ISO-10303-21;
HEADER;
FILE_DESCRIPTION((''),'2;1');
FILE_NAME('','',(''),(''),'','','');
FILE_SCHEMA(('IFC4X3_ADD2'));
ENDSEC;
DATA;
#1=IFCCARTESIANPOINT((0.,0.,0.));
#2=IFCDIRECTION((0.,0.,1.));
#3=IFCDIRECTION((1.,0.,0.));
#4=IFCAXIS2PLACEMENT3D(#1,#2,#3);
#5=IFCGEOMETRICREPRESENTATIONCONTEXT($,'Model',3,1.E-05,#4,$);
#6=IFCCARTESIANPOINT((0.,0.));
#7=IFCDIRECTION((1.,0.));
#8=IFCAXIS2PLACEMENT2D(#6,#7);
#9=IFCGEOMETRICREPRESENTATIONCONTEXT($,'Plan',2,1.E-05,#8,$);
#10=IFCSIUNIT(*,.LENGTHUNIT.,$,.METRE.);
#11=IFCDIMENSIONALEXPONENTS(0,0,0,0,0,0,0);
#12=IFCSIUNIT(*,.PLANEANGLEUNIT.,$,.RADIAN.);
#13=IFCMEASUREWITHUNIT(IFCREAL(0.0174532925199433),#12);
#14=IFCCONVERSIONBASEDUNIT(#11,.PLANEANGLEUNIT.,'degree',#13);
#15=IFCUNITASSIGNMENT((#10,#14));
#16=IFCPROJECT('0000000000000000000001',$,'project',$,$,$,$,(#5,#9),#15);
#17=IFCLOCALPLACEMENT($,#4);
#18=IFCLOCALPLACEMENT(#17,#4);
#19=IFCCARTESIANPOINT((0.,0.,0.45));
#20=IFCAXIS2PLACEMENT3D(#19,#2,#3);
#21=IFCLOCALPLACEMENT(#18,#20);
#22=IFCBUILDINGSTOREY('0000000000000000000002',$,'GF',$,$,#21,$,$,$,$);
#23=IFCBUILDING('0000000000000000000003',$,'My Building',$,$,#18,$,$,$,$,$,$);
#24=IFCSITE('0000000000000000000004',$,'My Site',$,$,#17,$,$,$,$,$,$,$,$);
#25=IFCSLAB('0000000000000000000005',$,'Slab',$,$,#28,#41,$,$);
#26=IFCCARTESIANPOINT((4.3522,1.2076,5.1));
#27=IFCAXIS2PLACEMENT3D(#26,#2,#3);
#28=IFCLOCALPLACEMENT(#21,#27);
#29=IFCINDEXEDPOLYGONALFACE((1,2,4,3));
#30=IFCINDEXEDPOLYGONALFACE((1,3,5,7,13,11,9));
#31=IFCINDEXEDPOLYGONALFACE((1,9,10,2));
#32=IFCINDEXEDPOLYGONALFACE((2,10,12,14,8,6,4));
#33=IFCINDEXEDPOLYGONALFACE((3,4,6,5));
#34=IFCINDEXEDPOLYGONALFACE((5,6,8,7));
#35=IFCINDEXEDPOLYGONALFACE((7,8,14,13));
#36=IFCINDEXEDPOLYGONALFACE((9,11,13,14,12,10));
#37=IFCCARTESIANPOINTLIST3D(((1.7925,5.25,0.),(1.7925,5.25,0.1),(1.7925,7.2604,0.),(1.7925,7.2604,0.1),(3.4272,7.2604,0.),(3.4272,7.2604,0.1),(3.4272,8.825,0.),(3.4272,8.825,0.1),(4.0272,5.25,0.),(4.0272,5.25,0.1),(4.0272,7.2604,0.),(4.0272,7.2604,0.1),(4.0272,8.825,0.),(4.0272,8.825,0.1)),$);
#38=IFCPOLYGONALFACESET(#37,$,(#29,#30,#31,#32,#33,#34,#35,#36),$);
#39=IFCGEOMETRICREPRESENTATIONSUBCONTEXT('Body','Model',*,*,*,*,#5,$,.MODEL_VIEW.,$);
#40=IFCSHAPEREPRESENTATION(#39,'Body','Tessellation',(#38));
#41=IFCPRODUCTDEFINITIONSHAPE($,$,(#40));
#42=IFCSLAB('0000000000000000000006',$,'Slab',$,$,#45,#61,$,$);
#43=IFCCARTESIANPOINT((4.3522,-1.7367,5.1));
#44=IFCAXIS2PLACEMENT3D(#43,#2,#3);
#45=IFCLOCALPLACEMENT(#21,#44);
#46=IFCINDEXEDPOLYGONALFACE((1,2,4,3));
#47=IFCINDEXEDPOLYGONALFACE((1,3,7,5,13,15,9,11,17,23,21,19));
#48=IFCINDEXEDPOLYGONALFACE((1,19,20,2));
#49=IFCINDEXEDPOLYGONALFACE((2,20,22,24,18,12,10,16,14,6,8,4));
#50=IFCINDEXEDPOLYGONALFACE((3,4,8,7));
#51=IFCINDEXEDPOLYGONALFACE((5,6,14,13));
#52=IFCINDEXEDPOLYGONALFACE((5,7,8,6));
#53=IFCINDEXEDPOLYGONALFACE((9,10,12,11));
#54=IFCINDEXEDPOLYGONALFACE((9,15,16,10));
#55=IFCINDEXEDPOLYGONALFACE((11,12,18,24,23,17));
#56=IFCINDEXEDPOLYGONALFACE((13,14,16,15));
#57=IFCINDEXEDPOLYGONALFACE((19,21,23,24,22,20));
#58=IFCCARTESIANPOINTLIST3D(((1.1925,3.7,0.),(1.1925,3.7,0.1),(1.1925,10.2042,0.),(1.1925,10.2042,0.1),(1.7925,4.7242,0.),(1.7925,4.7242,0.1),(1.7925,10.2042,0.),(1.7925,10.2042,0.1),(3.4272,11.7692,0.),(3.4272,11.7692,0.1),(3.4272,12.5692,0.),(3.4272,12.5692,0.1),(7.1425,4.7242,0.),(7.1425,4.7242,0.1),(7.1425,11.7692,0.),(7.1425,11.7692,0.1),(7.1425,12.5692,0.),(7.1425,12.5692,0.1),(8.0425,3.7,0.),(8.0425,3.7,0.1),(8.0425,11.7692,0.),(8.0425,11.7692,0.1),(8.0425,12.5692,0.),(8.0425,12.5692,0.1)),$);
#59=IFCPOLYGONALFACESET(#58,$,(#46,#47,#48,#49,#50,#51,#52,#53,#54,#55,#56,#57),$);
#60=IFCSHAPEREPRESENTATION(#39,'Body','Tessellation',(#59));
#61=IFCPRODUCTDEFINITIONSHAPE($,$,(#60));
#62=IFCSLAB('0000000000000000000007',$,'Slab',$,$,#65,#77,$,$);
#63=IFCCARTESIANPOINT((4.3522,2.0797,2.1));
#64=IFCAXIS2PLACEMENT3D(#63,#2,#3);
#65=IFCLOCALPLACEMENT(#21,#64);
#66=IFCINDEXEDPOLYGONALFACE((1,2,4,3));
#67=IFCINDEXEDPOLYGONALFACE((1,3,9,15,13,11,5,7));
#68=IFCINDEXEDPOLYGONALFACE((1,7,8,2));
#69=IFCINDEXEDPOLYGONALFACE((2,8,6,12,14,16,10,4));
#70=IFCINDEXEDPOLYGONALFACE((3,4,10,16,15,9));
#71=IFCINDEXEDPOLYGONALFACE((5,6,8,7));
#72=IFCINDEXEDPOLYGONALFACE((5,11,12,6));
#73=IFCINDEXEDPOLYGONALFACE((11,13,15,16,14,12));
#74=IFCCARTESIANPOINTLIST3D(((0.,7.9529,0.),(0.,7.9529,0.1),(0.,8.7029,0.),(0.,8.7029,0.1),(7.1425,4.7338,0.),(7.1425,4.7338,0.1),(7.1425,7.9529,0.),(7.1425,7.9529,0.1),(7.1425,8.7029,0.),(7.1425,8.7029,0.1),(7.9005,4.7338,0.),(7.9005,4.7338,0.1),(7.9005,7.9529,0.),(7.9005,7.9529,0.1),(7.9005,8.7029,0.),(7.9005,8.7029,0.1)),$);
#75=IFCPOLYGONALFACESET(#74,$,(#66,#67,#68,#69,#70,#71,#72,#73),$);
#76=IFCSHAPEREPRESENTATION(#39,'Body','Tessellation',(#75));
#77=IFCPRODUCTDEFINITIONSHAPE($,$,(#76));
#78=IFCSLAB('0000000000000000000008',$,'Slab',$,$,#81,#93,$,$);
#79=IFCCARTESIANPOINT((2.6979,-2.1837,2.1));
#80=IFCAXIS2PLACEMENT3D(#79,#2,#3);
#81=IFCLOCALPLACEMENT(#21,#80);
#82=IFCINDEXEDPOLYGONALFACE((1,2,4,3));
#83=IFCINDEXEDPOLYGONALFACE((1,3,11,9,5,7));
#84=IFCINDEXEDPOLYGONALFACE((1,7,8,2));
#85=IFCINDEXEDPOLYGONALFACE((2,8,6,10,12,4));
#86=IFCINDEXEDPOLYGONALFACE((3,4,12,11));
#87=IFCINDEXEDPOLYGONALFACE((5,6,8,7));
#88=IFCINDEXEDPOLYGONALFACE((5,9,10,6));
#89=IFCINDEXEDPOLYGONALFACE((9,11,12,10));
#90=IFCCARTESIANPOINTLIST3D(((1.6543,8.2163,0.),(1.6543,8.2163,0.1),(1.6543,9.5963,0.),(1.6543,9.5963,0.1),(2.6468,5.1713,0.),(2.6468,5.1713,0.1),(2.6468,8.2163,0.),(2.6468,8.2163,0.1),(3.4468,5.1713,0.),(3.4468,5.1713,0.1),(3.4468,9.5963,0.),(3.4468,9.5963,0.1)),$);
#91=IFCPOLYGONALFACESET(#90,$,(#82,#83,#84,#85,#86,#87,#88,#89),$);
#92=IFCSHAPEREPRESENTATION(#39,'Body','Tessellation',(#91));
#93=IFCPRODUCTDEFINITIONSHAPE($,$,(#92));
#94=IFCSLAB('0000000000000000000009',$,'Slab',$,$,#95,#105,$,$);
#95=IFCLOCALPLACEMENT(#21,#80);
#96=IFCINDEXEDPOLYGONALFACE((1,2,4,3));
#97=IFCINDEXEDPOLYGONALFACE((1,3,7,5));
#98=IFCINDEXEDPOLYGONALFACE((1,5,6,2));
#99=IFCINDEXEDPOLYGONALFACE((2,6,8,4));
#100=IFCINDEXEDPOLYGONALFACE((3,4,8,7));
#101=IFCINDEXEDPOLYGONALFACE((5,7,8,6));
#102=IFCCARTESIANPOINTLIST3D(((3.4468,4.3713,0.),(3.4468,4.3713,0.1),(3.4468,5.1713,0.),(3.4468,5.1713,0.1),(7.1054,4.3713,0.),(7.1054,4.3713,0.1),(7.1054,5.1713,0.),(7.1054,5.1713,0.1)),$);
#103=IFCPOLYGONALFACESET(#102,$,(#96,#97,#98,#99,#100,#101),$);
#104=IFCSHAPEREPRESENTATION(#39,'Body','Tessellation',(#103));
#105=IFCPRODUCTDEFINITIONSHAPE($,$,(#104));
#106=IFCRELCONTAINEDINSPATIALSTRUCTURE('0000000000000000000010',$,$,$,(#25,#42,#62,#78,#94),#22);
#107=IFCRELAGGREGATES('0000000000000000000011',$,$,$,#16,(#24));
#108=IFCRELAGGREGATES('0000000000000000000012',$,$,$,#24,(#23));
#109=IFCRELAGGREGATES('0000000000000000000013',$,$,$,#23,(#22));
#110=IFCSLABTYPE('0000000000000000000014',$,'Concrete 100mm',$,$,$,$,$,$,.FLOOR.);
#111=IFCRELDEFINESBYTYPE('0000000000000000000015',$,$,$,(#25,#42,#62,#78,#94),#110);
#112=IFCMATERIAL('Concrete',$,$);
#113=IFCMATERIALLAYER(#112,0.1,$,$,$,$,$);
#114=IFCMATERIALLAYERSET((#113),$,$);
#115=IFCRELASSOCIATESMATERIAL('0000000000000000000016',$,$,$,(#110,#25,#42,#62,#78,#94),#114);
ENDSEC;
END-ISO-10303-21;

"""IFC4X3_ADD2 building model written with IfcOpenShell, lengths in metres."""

from ifc_helpers import new_model, entity, si_unit, converted_unit, frame, origin_with_axes, origin_2d_with_axis, place, context, subcontext, project, spatial, indexed_curve, outline, extrude, material, layer, layer_set, layer_usage, type_object, element, save


model = new_model("IFC4X3_ADD2")

# Units and contexts
model_context = context("Model", 3, precision=1e-05, world=origin_with_axes())
plan_context = context("Plan", 2, precision=1e-05, world=origin_2d_with_axis())
body_context_1 = subcontext(model_context, "Body", "Model", "MODEL_VIEW")
ifc_project = project(units=[si_unit("LENGTHUNIT", "METRE"), converted_unit("PLANEANGLEUNIT", "degree", entity("IfcReal", 0.0174532925199433), si_unit("PLANEANGLEUNIT", "RADIAN"), dimensions=[0, 0, 0, 0, 0, 0, 0])], contexts=[model_context, plan_context])

# Site, building, storey
site_placement = place(None, origin_with_axes())
site = spatial("IfcSite", under=ifc_project, at=site_placement, Name="My Site")
building_placement = place(site_placement, origin_with_axes())
building = spatial("IfcBuilding", under=site, at=building_placement, Name="My Building")
storey_placement = place(building_placement, frame((0.0, 0.0, 0.45), z_axis=(0.0, 0.0, 1.0), x_axis=(1.0, 0.0, 0.0)))
storey = spatial("IfcBuildingStorey", under=building, at=storey_placement, Name="GF")

# Slabs
ifc_material_1 = material(Name="Concrete")
ifc_layer_1 = layer(ifc_material_1, 0.1)
ifc_layer_set_1 = layer_set([ifc_layer_1])
ifc_layer_usage_1 = layer_usage(ifc_layer_set_1, "AXIS3", "POSITIVE", 0.0)
slab_type = type_object("IfcSlabType", Name="Concrete 100mm", PredefinedType="FLOOR", material=ifc_layer_set_1)
slab_1_placement = place(storey_placement, frame((4.3522, 1.2076, 5.1), z_axis=(0.0, 0.0, 1.0), x_axis=(1.0, 0.0, 0.0)))
element("IfcSlab", 1, at=slab_1_placement, inside=storey, type_object=slab_type, material=ifc_layer_usage_1, Name="Slab", context=body_context_1, shape_type="SweptSolid", body=[
    extrude(outline(indexed_curve([(1.7925, 7.2604), (1.7925, 5.25), (4.0272, 5.25), (4.0272, 7.2604), (4.0272, 8.825), (3.4272, 8.825), (3.4272, 7.2604), (1.7925, 7.2604)])), origin_with_axes(), (0.0, 0.0, 1.0), 0.1),
])
ifc_layer_usage_2 = layer_usage(ifc_layer_set_1, "AXIS3", "POSITIVE", 0.0)
slab_2_placement = place(storey_placement, frame((4.3522, -1.7367, 5.1), z_axis=(0.0, 0.0, 1.0), x_axis=(1.0, 0.0, 0.0)))
element("IfcSlab", 2, at=slab_2_placement, inside=storey, type_object=slab_type, material=ifc_layer_usage_2, Name="Slab", context=body_context_1, shape_type="SweptSolid", body=[
    extrude(outline(indexed_curve([(8.0425, 11.7692), (8.0425, 12.5692), (7.1425, 12.5692), (3.4272, 12.5692), (3.4272, 11.7692), (7.1425, 11.7692), (7.1425, 4.7242), (1.7925, 4.7242), (1.7925, 10.2042), (1.1925, 10.2042), (1.1925, 3.7), (8.0425, 3.7), (8.0425, 11.7692)])), origin_with_axes(), (0.0, 0.0, 1.0), 0.1),
])
ifc_layer_usage_3 = layer_usage(ifc_layer_set_1, "AXIS3", "POSITIVE", 0.0)
slab_3_placement = place(storey_placement, frame((4.3522, 2.0797, 2.1), z_axis=(0.0, 0.0, 1.0), x_axis=(1.0, 0.0, 0.0)))
element("IfcSlab", 3, at=slab_3_placement, inside=storey, type_object=slab_type, material=ifc_layer_usage_3, Name="Slab", context=body_context_1, shape_type="SweptSolid", body=[
    extrude(outline(indexed_curve([(0.0, 8.7029), (7.1425, 8.7029), (7.9005, 8.7029), (7.9005, 7.9529), (7.9005, 4.7338), (7.1425, 4.7338), (7.1425, 7.9529), (0.0, 7.9529), (0.0, 8.7029)])), origin_with_axes(), (0.0, 0.0, 1.0), 0.1),
])
ifc_layer_usage_4 = layer_usage(ifc_layer_set_1, "AXIS3", "POSITIVE", 0.0)
slab_4_placement = place(storey_placement, frame((2.6979, -2.1837, 2.1), z_axis=(0.0, 0.0, 1.0), x_axis=(1.0, 0.0, 0.0)))
element("IfcSlab", 4, at=slab_4_placement, inside=storey, type_object=slab_type, material=ifc_layer_usage_4, Name="Slab", context=body_context_1, shape_type="SweptSolid", body=[
    extrude(outline(indexed_curve([(2.6468, 8.2163), (1.6543, 8.2163), (1.6543, 9.5963), (3.4468, 9.5963), (3.4468, 5.1713), (2.6468, 5.1713), (2.6468, 8.2163)])), origin_with_axes(), (0.0, 0.0, 1.0), 0.1),
])
ifc_layer_usage_5 = layer_usage(ifc_layer_set_1, "AXIS3", "POSITIVE", 0.0)
slab_5_placement = place(storey_placement, frame((2.6979, -2.1837, 2.1), z_axis=(0.0, 0.0, 1.0), x_axis=(1.0, 0.0, 0.0)))
element("IfcSlab", 5, at=slab_5_placement, inside=storey, type_object=slab_type, material=ifc_layer_usage_5, Name="Slab", context=body_context_1, shape_type="SweptSolid", body=[
    extrude(outline(indexed_curve([(7.1054, 5.1713), (7.1054, 4.3713), (3.4468, 4.3713), (3.4468, 5.1713), (7.1054, 5.1713)])), origin_with_axes(), (0.0, 0.0, 1.0), 0.1),
])

save(model, "model.ifc")
